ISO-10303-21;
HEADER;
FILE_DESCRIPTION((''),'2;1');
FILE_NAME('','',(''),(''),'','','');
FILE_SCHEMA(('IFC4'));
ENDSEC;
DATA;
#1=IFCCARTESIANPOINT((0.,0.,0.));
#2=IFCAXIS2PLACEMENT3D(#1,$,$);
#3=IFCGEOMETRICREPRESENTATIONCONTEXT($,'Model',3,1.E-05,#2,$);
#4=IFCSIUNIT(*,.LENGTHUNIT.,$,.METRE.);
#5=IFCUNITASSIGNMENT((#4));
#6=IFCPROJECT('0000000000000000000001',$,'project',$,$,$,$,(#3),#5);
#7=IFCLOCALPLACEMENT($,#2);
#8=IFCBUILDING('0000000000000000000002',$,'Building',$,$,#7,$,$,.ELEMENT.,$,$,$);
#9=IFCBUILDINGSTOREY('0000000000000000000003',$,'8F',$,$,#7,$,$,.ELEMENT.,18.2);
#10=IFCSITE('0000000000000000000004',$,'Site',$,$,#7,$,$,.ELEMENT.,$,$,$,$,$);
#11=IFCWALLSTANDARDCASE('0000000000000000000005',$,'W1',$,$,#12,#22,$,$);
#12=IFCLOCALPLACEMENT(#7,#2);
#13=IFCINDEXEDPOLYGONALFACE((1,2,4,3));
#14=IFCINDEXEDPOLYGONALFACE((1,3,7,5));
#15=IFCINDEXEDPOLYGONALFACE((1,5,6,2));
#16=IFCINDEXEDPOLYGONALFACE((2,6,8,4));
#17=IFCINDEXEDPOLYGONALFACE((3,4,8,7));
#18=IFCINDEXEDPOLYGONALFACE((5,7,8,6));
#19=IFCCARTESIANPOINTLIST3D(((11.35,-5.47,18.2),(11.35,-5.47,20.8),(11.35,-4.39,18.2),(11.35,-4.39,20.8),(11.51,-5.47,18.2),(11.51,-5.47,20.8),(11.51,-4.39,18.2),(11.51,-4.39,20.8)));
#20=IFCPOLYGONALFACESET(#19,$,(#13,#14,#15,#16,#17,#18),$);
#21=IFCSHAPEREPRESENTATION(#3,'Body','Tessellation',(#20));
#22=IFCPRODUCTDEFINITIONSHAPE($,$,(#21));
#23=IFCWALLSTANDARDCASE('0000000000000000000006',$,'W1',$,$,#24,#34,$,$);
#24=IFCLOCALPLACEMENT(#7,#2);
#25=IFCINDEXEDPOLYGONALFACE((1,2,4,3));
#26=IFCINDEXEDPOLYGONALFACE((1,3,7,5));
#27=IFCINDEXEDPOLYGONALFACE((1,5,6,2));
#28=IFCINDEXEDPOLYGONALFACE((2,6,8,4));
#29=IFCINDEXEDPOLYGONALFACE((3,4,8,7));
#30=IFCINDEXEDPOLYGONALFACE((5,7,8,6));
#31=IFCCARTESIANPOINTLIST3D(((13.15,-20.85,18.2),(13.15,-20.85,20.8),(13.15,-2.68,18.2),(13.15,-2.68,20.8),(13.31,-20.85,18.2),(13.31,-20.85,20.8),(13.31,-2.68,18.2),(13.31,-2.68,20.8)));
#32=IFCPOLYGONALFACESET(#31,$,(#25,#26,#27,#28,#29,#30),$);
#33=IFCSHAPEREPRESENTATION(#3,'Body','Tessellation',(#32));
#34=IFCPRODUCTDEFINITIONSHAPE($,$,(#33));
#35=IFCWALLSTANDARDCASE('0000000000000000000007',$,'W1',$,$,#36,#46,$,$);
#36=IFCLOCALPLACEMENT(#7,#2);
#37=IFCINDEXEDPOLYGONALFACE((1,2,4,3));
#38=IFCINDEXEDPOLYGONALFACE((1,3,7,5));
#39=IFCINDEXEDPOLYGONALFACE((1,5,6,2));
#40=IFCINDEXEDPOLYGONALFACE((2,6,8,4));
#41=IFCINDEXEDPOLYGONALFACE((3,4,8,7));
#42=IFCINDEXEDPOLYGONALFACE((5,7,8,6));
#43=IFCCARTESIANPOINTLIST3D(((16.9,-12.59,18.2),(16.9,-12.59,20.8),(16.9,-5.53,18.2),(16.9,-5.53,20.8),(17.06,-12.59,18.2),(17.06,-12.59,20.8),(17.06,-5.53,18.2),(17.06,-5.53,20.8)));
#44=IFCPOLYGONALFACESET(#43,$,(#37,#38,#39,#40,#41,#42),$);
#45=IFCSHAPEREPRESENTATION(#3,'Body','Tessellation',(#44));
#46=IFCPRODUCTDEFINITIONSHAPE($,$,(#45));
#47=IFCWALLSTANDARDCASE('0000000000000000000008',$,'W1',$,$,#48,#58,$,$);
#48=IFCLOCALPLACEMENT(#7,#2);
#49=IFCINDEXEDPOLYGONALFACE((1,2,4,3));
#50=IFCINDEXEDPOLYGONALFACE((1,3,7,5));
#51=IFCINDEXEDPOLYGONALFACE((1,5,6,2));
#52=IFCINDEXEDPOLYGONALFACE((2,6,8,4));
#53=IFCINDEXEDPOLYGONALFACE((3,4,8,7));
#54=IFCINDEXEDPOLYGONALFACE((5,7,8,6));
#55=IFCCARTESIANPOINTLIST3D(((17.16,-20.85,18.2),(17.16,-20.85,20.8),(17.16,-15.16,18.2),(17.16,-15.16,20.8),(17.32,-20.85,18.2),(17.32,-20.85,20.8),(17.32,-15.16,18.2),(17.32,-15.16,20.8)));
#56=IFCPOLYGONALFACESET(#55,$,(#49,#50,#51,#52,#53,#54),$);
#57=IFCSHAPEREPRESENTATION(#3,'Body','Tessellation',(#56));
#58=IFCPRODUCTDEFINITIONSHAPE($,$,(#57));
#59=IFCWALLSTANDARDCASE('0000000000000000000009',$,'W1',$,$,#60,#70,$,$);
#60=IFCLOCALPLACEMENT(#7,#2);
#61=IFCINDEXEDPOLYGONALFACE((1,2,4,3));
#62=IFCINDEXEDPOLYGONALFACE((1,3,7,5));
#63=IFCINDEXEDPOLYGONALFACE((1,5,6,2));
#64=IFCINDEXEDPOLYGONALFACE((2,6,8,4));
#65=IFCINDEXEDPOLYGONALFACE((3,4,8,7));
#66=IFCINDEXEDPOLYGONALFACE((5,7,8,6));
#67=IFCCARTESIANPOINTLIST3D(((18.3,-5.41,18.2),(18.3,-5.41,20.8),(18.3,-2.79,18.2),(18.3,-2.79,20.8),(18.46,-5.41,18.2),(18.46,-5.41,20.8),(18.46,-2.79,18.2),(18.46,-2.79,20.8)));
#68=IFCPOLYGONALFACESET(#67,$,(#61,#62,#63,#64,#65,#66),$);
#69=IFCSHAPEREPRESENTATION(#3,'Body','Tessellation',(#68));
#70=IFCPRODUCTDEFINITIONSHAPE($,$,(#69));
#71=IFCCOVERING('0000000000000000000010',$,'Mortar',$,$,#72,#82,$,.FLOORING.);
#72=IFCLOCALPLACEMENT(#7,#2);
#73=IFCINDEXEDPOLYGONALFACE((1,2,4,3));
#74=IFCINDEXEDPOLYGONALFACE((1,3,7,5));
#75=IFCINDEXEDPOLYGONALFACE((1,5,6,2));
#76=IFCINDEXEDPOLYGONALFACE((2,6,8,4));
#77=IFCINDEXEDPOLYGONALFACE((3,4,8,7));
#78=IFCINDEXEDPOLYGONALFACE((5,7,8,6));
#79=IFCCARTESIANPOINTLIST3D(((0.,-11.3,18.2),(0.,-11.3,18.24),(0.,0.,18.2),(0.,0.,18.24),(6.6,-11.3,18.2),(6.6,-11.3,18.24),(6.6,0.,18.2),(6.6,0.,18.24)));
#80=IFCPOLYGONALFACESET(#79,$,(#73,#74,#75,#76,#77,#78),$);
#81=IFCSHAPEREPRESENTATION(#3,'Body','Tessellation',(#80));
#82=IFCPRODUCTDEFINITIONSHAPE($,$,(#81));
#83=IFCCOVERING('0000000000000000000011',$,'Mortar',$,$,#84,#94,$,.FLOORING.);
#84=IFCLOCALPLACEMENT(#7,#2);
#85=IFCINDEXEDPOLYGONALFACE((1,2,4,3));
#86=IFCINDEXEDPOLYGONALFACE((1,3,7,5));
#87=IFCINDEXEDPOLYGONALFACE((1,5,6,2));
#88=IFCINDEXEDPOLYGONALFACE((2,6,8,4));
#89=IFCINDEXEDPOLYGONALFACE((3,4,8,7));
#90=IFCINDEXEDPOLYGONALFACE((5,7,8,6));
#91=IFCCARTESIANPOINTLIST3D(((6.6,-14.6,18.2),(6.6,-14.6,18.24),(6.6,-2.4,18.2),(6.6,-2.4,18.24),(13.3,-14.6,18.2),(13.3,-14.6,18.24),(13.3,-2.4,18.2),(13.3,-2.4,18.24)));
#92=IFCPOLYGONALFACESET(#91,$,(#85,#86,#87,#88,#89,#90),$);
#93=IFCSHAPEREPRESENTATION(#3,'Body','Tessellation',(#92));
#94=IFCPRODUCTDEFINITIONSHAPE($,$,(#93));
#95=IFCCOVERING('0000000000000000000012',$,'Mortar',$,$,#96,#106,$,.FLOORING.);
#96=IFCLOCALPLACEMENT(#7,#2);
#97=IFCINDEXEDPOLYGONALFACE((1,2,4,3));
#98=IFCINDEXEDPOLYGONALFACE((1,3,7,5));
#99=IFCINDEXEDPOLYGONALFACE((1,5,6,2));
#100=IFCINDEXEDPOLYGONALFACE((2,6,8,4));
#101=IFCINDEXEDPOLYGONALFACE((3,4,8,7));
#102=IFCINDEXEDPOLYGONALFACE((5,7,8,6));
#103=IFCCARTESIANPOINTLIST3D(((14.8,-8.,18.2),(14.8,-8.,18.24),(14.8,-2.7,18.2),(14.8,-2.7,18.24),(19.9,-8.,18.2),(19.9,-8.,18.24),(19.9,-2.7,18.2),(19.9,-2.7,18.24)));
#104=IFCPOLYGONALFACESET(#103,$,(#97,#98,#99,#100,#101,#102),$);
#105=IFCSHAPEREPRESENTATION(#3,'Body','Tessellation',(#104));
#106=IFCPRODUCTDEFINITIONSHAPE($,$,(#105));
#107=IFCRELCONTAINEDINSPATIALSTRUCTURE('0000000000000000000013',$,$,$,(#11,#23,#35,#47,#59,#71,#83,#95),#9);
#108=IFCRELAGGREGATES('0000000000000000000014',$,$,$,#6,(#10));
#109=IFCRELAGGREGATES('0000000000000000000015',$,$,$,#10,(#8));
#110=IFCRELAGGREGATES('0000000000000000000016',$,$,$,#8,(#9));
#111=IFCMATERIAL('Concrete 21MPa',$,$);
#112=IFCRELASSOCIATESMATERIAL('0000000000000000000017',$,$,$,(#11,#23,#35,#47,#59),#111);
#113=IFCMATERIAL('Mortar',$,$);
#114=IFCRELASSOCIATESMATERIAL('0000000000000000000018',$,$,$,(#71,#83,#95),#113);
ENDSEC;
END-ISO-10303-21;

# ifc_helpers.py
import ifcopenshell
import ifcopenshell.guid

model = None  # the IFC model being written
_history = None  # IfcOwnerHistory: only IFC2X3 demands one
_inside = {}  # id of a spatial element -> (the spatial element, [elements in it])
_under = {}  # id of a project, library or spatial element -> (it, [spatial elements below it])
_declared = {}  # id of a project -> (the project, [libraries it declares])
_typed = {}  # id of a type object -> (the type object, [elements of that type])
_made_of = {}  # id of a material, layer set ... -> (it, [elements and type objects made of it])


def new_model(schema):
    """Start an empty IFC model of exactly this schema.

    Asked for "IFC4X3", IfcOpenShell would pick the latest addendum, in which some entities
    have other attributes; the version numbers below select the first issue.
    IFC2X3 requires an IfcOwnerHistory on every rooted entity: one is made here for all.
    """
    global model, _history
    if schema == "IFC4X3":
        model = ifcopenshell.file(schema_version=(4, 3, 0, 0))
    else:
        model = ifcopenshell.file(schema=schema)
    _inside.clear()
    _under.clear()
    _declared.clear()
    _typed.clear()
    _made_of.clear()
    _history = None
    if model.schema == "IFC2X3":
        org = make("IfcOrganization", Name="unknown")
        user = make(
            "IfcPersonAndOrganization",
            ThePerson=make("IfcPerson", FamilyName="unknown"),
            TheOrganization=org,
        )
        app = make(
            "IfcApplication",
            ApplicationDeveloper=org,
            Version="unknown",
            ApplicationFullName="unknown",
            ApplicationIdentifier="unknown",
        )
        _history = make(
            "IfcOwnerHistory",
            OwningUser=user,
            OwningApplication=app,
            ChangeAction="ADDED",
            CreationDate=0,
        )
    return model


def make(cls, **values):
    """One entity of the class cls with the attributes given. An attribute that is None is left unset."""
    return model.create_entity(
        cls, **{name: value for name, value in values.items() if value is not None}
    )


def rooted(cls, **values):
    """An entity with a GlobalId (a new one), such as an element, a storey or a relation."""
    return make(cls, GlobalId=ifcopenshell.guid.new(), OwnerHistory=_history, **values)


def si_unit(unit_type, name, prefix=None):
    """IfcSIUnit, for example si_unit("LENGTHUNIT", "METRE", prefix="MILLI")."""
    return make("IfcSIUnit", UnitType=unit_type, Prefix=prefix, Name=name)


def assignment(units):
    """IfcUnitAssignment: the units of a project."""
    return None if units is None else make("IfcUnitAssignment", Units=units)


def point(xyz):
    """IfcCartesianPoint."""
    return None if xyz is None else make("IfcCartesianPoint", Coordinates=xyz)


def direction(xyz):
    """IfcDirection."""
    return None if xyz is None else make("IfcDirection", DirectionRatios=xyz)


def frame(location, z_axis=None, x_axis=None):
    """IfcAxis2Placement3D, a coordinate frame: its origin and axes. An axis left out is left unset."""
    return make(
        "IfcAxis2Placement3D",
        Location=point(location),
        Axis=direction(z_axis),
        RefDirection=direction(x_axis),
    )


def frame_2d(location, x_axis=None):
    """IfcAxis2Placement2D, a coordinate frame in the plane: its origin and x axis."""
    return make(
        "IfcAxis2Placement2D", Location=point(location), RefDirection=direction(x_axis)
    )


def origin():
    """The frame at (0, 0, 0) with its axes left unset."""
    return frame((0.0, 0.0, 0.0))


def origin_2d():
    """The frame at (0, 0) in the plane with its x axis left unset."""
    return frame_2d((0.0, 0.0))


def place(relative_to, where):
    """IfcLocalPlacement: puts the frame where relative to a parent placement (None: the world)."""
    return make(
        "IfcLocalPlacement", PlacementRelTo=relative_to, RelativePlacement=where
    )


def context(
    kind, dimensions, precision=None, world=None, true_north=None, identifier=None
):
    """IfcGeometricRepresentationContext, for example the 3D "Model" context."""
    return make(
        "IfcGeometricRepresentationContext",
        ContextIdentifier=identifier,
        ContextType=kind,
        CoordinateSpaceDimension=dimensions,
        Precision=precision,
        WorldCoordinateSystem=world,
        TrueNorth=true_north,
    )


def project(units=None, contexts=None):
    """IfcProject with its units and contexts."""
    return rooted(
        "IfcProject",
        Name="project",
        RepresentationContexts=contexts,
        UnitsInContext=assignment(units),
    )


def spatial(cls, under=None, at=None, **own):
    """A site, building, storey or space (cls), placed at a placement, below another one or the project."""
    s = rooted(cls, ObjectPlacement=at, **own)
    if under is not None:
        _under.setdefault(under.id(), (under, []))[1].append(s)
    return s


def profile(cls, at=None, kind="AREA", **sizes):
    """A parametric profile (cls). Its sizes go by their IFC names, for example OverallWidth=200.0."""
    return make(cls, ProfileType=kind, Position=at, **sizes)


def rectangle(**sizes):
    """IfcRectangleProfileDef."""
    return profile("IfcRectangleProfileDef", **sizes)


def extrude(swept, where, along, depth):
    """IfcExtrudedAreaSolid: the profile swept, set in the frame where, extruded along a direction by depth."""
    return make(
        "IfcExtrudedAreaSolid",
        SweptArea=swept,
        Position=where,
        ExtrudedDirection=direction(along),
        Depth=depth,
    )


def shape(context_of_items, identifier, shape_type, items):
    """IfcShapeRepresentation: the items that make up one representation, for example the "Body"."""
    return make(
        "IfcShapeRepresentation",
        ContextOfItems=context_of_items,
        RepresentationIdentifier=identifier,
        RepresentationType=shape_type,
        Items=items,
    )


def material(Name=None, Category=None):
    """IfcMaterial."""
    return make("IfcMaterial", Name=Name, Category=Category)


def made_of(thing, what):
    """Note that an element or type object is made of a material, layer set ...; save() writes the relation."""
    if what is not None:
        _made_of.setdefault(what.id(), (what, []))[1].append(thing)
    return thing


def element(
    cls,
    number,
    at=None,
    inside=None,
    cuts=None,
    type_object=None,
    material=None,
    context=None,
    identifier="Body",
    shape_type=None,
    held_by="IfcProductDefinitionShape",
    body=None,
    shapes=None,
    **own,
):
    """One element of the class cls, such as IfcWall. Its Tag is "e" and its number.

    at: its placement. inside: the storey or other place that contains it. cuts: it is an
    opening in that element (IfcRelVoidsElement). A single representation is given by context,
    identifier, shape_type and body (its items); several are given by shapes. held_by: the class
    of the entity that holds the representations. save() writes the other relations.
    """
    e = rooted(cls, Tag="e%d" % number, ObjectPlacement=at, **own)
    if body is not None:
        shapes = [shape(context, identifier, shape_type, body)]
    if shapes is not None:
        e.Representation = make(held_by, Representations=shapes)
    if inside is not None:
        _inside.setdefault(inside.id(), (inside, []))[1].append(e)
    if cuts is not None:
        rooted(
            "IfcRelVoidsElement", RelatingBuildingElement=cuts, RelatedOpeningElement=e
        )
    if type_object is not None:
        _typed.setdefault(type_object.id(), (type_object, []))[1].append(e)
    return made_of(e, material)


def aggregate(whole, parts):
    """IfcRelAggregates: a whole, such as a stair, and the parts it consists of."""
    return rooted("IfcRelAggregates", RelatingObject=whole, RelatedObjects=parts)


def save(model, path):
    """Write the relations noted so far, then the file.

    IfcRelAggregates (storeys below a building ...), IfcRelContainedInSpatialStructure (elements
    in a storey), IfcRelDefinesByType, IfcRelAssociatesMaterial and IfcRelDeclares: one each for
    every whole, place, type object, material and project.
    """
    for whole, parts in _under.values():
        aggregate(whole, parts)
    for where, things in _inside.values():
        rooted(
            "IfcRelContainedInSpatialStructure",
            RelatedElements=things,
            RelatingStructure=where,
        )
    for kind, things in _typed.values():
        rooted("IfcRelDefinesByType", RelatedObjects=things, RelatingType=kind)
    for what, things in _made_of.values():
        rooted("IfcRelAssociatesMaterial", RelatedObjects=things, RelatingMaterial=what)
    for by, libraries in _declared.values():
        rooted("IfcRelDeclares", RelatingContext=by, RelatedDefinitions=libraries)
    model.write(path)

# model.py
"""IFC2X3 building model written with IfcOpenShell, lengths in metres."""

from ifc_helpers import new_model, si_unit, frame, origin, origin_2d, place, context, project, spatial, rectangle, extrude, material, element, save


model = new_model("IFC2X3")

# Units and contexts
model_context = context("Model", 3, precision=1e-05, world=origin())
ifc_project = project(units=[si_unit("LENGTHUNIT", "METRE")], contexts=[model_context])

# Site, building, storey
placement = place(None, origin())
site = spatial("IfcSite", under=ifc_project, at=placement, Name="Site", CompositionType="ELEMENT")
building = spatial("IfcBuilding", under=site, at=placement, Name="Building", CompositionType="ELEMENT")
storey = spatial("IfcBuildingStorey", under=building, at=placement, Name="8F", CompositionType="ELEMENT", Elevation=18.2)

# Shared definitions
ifc_material_1 = material(Name="Concrete 21MPa")

# Walls
wall_1_placement = place(None, frame((11.43, -4.93, 18.2)))
element("IfcWallStandardCase", 1, at=wall_1_placement, inside=storey, material=ifc_material_1, Name="W1", context=model_context, shape_type="SweptSolid", body=[
    extrude(rectangle(XDim=0.16, YDim=1.08, at=origin_2d()), origin(), (0.0, 0.0, 1.0), 2.6),
])
wall_2_placement = place(None, frame((13.23, -11.765, 18.2)))
element("IfcWallStandardCase", 2, at=wall_2_placement, inside=storey, material=ifc_material_1, Name="W1", context=model_context, shape_type="SweptSolid", body=[
    extrude(rectangle(XDim=0.16, YDim=18.17, at=origin_2d()), origin(), (0.0, 0.0, 1.0), 2.6),
])
wall_3_placement = place(None, frame((16.98, -9.06, 18.2)))
element("IfcWallStandardCase", 3, at=wall_3_placement, inside=storey, material=ifc_material_1, Name="W1", context=model_context, shape_type="SweptSolid", body=[
    extrude(rectangle(XDim=0.16, YDim=7.06, at=origin_2d()), origin(), (0.0, 0.0, 1.0), 2.6),
])
wall_4_placement = place(None, frame((17.24, -18.005, 18.2)))
element("IfcWallStandardCase", 4, at=wall_4_placement, inside=storey, material=ifc_material_1, Name="W1", context=model_context, shape_type="SweptSolid", body=[
    extrude(rectangle(XDim=0.16, YDim=5.69, at=origin_2d()), origin(), (0.0, 0.0, 1.0), 2.6),
])
wall_5_placement = place(None, frame((18.38, -4.1, 18.2)))
element("IfcWallStandardCase", 5, at=wall_5_placement, inside=storey, material=ifc_material_1, Name="W1", context=model_context, shape_type="SweptSolid", body=[
    extrude(rectangle(XDim=0.16, YDim=2.62, at=origin_2d()), origin(), (0.0, 0.0, 1.0), 2.6),
])

# Coverings
ifc_material_2 = material(Name="Mortar")
covering_1_placement = place(None, frame((3.3, -5.65, 18.2)))
element("IfcCovering", 6, at=covering_1_placement, inside=storey, material=ifc_material_2, Name="Mortar", PredefinedType="FLOORING", context=model_context, shape_type="SweptSolid", body=[
    extrude(rectangle(XDim=6.6, YDim=11.3, at=origin_2d()), origin(), (0.0, 0.0, 1.0), 0.04),
])
covering_2_placement = place(None, frame((9.95, -8.5, 18.2)))
element("IfcCovering", 7, at=covering_2_placement, inside=storey, material=ifc_material_2, Name="Mortar", PredefinedType="FLOORING", context=model_context, shape_type="SweptSolid", body=[
    extrude(rectangle(XDim=6.7, YDim=12.2, at=origin_2d()), origin(), (0.0, 0.0, 1.0), 0.04),
])
covering_3_placement = place(None, frame((17.35, -5.35, 18.2)))
element("IfcCovering", 8, at=covering_3_placement, inside=storey, material=ifc_material_2, Name="Mortar", PredefinedType="FLOORING", context=model_context, shape_type="SweptSolid", body=[
    extrude(rectangle(XDim=5.1, YDim=5.3, at=origin_2d()), origin(), (0.0, 0.0, 1.0), 0.04),
])

save(model, "model.ifc")
